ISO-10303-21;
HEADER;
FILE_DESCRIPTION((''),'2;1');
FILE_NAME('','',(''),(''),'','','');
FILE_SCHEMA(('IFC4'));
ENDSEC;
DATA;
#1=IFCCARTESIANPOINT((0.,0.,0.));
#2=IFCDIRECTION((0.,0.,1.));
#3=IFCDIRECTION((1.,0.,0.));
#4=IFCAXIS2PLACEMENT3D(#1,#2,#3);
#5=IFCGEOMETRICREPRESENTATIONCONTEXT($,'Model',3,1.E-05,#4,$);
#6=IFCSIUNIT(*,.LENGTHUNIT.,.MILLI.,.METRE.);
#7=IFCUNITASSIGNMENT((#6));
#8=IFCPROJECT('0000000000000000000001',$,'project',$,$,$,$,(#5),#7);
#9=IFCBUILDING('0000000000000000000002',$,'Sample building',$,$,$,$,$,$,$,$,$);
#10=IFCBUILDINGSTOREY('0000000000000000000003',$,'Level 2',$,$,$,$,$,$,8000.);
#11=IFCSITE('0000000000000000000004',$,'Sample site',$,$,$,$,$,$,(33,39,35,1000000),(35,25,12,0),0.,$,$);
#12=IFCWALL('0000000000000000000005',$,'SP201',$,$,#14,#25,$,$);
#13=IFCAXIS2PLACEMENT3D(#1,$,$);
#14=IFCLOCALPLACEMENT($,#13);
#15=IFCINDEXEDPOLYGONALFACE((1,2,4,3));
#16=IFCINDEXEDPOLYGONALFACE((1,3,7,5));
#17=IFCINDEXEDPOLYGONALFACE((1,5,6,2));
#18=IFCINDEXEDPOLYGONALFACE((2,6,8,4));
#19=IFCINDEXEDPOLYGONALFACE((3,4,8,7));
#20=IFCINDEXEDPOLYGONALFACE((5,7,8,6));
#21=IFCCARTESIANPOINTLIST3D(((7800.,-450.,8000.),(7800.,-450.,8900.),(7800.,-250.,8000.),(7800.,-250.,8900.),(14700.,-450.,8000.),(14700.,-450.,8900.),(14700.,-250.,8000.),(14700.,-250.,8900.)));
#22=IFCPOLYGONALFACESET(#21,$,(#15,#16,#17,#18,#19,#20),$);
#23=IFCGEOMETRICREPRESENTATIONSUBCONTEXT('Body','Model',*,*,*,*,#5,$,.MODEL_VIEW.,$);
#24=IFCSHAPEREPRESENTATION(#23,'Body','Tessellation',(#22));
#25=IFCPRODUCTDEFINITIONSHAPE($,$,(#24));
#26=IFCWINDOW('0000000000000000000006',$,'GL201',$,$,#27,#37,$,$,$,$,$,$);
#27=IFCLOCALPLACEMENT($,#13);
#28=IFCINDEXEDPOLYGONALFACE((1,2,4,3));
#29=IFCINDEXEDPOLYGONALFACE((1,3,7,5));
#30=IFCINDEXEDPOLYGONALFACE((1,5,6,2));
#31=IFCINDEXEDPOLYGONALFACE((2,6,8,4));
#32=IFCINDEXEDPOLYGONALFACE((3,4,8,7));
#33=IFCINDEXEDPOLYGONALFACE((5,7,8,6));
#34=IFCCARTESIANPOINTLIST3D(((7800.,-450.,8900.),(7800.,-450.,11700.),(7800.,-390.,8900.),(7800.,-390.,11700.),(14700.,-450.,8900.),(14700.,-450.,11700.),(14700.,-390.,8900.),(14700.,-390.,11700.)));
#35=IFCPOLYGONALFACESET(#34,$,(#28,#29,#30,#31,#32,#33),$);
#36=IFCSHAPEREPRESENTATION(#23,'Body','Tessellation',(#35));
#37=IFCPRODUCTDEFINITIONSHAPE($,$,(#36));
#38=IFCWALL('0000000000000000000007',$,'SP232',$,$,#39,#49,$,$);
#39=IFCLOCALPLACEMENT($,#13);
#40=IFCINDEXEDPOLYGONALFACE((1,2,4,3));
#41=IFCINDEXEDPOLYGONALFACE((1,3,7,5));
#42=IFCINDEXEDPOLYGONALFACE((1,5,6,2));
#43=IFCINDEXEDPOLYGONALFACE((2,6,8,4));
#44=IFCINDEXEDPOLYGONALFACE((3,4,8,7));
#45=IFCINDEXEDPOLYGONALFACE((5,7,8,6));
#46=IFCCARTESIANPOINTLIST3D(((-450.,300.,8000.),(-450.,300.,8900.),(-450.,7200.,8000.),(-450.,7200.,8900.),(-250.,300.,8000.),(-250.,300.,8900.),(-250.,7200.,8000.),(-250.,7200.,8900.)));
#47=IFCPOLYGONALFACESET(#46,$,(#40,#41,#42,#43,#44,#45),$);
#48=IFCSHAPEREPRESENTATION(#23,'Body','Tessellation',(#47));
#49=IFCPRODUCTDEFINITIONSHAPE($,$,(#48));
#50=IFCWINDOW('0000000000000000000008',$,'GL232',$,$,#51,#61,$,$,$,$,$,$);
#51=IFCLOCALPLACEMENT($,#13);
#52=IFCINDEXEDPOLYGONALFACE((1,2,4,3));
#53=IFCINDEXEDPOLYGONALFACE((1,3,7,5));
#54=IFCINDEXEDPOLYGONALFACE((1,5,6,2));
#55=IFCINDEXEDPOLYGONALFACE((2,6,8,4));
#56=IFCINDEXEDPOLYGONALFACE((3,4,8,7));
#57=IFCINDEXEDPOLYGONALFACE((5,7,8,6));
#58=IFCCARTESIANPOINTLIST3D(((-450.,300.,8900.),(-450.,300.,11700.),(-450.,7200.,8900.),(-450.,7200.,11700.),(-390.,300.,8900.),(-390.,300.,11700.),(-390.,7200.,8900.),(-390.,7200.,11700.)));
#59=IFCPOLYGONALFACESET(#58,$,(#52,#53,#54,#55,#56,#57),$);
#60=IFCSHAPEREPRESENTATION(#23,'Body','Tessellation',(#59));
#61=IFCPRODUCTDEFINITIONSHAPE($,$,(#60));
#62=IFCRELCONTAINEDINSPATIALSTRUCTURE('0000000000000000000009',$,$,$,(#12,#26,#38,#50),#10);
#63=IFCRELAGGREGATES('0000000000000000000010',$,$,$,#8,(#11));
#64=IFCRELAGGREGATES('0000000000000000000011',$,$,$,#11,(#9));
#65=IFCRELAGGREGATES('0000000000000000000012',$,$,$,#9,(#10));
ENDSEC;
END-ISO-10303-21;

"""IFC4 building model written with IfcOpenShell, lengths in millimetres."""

from ifc_helpers import new_model, si_unit, frame, origin_with_axes, place, context, subcontext, project, spatial, indexed_curve, outline, extrude, element, save


model = new_model("IFC4")

# Units and contexts
model_context = context("Model", 3, precision=1e-05, world=origin_with_axes())
body_context = subcontext(model_context, "Body", "Model", "MODEL_VIEW")
ifc_project = project(units=[si_unit("LENGTHUNIT", "METRE", prefix="MILLI")], contexts=[model_context])

# Site, building, storey
site = spatial("IfcSite", under=ifc_project, Name="Sample site", RefLatitude=(33, 39, 35, 1000000), RefLongitude=(35, 25, 12, 0), RefElevation=0.0)
building = spatial("IfcBuilding", under=site, Name="Sample building")
storey = spatial("IfcBuildingStorey", under=building, Name="Level 2", Elevation=8000.0)

# Wall
wall_1_placement = place(None, frame((7800.0, -450.0, 8000.0), z_axis=(0.0, 0.0, 1.0), x_axis=(1.0, 0.0, 0.0)))
element("IfcWall", 1, at=wall_1_placement, inside=storey, Name="SP201", context=body_context, shape_type="SweptSolid", body=[
    extrude(outline(indexed_curve([(0.0, 0.0), (0.0, 200.0), (6900.0, 200.0), (6900.0, 0.0), (0.0, 0.0)], self_intersect=False)), origin_with_axes(), (0.0, 0.0, 1.0), 900.0),
])

# Window
window_1_placement = place(None, frame((7800.0, -450.0, 8900.0), z_axis=(0.0, 0.0, 1.0), x_axis=(1.0, 0.0, 0.0)))
element("IfcWindow", 2, at=window_1_placement, inside=storey, Name="GL201", context=body_context, shape_type="SweptSolid", body=[
    extrude(outline(indexed_curve([(0.0, 0.0), (0.0, 60.0), (6900.0, 60.0), (6900.0, 0.0), (0.0, 0.0)], self_intersect=False)), origin_with_axes(), (0.0, 0.0, 1.0), 2800.0),
])

# Wall
wall_2_placement = place(None, frame((-450.0, 7200.0, 8000.0), z_axis=(0.0, 0.0, 1.0), x_axis=(0.0, -1.0, 0.0)))
element("IfcWall", 3, at=wall_2_placement, inside=storey, Name="SP232", context=body_context, shape_type="SweptSolid", body=[
    extrude(outline(indexed_curve([(0.0, 0.0), (0.0, 200.0), (6900.0, 200.0), (6900.0, 0.0), (0.0, 0.0)], self_intersect=False)), origin_with_axes(), (0.0, 0.0, 1.0), 900.0),
])

# Window
window_2_placement = place(None, frame((-450.0, 7200.0, 8900.0), z_axis=(0.0, 0.0, 1.0), x_axis=(0.0, -1.0, 0.0)))
element("IfcWindow", 4, at=window_2_placement, inside=storey, Name="GL232", context=body_context, shape_type="SweptSolid", body=[
    extrude(outline(indexed_curve([(0.0, 0.0), (0.0, 60.0), (6900.0, 60.0), (6900.0, 0.0), (0.0, 0.0)], self_intersect=False)), origin_with_axes(), (0.0, 0.0, 1.0), 2800.0),
])

save(model, "model.ifc")
